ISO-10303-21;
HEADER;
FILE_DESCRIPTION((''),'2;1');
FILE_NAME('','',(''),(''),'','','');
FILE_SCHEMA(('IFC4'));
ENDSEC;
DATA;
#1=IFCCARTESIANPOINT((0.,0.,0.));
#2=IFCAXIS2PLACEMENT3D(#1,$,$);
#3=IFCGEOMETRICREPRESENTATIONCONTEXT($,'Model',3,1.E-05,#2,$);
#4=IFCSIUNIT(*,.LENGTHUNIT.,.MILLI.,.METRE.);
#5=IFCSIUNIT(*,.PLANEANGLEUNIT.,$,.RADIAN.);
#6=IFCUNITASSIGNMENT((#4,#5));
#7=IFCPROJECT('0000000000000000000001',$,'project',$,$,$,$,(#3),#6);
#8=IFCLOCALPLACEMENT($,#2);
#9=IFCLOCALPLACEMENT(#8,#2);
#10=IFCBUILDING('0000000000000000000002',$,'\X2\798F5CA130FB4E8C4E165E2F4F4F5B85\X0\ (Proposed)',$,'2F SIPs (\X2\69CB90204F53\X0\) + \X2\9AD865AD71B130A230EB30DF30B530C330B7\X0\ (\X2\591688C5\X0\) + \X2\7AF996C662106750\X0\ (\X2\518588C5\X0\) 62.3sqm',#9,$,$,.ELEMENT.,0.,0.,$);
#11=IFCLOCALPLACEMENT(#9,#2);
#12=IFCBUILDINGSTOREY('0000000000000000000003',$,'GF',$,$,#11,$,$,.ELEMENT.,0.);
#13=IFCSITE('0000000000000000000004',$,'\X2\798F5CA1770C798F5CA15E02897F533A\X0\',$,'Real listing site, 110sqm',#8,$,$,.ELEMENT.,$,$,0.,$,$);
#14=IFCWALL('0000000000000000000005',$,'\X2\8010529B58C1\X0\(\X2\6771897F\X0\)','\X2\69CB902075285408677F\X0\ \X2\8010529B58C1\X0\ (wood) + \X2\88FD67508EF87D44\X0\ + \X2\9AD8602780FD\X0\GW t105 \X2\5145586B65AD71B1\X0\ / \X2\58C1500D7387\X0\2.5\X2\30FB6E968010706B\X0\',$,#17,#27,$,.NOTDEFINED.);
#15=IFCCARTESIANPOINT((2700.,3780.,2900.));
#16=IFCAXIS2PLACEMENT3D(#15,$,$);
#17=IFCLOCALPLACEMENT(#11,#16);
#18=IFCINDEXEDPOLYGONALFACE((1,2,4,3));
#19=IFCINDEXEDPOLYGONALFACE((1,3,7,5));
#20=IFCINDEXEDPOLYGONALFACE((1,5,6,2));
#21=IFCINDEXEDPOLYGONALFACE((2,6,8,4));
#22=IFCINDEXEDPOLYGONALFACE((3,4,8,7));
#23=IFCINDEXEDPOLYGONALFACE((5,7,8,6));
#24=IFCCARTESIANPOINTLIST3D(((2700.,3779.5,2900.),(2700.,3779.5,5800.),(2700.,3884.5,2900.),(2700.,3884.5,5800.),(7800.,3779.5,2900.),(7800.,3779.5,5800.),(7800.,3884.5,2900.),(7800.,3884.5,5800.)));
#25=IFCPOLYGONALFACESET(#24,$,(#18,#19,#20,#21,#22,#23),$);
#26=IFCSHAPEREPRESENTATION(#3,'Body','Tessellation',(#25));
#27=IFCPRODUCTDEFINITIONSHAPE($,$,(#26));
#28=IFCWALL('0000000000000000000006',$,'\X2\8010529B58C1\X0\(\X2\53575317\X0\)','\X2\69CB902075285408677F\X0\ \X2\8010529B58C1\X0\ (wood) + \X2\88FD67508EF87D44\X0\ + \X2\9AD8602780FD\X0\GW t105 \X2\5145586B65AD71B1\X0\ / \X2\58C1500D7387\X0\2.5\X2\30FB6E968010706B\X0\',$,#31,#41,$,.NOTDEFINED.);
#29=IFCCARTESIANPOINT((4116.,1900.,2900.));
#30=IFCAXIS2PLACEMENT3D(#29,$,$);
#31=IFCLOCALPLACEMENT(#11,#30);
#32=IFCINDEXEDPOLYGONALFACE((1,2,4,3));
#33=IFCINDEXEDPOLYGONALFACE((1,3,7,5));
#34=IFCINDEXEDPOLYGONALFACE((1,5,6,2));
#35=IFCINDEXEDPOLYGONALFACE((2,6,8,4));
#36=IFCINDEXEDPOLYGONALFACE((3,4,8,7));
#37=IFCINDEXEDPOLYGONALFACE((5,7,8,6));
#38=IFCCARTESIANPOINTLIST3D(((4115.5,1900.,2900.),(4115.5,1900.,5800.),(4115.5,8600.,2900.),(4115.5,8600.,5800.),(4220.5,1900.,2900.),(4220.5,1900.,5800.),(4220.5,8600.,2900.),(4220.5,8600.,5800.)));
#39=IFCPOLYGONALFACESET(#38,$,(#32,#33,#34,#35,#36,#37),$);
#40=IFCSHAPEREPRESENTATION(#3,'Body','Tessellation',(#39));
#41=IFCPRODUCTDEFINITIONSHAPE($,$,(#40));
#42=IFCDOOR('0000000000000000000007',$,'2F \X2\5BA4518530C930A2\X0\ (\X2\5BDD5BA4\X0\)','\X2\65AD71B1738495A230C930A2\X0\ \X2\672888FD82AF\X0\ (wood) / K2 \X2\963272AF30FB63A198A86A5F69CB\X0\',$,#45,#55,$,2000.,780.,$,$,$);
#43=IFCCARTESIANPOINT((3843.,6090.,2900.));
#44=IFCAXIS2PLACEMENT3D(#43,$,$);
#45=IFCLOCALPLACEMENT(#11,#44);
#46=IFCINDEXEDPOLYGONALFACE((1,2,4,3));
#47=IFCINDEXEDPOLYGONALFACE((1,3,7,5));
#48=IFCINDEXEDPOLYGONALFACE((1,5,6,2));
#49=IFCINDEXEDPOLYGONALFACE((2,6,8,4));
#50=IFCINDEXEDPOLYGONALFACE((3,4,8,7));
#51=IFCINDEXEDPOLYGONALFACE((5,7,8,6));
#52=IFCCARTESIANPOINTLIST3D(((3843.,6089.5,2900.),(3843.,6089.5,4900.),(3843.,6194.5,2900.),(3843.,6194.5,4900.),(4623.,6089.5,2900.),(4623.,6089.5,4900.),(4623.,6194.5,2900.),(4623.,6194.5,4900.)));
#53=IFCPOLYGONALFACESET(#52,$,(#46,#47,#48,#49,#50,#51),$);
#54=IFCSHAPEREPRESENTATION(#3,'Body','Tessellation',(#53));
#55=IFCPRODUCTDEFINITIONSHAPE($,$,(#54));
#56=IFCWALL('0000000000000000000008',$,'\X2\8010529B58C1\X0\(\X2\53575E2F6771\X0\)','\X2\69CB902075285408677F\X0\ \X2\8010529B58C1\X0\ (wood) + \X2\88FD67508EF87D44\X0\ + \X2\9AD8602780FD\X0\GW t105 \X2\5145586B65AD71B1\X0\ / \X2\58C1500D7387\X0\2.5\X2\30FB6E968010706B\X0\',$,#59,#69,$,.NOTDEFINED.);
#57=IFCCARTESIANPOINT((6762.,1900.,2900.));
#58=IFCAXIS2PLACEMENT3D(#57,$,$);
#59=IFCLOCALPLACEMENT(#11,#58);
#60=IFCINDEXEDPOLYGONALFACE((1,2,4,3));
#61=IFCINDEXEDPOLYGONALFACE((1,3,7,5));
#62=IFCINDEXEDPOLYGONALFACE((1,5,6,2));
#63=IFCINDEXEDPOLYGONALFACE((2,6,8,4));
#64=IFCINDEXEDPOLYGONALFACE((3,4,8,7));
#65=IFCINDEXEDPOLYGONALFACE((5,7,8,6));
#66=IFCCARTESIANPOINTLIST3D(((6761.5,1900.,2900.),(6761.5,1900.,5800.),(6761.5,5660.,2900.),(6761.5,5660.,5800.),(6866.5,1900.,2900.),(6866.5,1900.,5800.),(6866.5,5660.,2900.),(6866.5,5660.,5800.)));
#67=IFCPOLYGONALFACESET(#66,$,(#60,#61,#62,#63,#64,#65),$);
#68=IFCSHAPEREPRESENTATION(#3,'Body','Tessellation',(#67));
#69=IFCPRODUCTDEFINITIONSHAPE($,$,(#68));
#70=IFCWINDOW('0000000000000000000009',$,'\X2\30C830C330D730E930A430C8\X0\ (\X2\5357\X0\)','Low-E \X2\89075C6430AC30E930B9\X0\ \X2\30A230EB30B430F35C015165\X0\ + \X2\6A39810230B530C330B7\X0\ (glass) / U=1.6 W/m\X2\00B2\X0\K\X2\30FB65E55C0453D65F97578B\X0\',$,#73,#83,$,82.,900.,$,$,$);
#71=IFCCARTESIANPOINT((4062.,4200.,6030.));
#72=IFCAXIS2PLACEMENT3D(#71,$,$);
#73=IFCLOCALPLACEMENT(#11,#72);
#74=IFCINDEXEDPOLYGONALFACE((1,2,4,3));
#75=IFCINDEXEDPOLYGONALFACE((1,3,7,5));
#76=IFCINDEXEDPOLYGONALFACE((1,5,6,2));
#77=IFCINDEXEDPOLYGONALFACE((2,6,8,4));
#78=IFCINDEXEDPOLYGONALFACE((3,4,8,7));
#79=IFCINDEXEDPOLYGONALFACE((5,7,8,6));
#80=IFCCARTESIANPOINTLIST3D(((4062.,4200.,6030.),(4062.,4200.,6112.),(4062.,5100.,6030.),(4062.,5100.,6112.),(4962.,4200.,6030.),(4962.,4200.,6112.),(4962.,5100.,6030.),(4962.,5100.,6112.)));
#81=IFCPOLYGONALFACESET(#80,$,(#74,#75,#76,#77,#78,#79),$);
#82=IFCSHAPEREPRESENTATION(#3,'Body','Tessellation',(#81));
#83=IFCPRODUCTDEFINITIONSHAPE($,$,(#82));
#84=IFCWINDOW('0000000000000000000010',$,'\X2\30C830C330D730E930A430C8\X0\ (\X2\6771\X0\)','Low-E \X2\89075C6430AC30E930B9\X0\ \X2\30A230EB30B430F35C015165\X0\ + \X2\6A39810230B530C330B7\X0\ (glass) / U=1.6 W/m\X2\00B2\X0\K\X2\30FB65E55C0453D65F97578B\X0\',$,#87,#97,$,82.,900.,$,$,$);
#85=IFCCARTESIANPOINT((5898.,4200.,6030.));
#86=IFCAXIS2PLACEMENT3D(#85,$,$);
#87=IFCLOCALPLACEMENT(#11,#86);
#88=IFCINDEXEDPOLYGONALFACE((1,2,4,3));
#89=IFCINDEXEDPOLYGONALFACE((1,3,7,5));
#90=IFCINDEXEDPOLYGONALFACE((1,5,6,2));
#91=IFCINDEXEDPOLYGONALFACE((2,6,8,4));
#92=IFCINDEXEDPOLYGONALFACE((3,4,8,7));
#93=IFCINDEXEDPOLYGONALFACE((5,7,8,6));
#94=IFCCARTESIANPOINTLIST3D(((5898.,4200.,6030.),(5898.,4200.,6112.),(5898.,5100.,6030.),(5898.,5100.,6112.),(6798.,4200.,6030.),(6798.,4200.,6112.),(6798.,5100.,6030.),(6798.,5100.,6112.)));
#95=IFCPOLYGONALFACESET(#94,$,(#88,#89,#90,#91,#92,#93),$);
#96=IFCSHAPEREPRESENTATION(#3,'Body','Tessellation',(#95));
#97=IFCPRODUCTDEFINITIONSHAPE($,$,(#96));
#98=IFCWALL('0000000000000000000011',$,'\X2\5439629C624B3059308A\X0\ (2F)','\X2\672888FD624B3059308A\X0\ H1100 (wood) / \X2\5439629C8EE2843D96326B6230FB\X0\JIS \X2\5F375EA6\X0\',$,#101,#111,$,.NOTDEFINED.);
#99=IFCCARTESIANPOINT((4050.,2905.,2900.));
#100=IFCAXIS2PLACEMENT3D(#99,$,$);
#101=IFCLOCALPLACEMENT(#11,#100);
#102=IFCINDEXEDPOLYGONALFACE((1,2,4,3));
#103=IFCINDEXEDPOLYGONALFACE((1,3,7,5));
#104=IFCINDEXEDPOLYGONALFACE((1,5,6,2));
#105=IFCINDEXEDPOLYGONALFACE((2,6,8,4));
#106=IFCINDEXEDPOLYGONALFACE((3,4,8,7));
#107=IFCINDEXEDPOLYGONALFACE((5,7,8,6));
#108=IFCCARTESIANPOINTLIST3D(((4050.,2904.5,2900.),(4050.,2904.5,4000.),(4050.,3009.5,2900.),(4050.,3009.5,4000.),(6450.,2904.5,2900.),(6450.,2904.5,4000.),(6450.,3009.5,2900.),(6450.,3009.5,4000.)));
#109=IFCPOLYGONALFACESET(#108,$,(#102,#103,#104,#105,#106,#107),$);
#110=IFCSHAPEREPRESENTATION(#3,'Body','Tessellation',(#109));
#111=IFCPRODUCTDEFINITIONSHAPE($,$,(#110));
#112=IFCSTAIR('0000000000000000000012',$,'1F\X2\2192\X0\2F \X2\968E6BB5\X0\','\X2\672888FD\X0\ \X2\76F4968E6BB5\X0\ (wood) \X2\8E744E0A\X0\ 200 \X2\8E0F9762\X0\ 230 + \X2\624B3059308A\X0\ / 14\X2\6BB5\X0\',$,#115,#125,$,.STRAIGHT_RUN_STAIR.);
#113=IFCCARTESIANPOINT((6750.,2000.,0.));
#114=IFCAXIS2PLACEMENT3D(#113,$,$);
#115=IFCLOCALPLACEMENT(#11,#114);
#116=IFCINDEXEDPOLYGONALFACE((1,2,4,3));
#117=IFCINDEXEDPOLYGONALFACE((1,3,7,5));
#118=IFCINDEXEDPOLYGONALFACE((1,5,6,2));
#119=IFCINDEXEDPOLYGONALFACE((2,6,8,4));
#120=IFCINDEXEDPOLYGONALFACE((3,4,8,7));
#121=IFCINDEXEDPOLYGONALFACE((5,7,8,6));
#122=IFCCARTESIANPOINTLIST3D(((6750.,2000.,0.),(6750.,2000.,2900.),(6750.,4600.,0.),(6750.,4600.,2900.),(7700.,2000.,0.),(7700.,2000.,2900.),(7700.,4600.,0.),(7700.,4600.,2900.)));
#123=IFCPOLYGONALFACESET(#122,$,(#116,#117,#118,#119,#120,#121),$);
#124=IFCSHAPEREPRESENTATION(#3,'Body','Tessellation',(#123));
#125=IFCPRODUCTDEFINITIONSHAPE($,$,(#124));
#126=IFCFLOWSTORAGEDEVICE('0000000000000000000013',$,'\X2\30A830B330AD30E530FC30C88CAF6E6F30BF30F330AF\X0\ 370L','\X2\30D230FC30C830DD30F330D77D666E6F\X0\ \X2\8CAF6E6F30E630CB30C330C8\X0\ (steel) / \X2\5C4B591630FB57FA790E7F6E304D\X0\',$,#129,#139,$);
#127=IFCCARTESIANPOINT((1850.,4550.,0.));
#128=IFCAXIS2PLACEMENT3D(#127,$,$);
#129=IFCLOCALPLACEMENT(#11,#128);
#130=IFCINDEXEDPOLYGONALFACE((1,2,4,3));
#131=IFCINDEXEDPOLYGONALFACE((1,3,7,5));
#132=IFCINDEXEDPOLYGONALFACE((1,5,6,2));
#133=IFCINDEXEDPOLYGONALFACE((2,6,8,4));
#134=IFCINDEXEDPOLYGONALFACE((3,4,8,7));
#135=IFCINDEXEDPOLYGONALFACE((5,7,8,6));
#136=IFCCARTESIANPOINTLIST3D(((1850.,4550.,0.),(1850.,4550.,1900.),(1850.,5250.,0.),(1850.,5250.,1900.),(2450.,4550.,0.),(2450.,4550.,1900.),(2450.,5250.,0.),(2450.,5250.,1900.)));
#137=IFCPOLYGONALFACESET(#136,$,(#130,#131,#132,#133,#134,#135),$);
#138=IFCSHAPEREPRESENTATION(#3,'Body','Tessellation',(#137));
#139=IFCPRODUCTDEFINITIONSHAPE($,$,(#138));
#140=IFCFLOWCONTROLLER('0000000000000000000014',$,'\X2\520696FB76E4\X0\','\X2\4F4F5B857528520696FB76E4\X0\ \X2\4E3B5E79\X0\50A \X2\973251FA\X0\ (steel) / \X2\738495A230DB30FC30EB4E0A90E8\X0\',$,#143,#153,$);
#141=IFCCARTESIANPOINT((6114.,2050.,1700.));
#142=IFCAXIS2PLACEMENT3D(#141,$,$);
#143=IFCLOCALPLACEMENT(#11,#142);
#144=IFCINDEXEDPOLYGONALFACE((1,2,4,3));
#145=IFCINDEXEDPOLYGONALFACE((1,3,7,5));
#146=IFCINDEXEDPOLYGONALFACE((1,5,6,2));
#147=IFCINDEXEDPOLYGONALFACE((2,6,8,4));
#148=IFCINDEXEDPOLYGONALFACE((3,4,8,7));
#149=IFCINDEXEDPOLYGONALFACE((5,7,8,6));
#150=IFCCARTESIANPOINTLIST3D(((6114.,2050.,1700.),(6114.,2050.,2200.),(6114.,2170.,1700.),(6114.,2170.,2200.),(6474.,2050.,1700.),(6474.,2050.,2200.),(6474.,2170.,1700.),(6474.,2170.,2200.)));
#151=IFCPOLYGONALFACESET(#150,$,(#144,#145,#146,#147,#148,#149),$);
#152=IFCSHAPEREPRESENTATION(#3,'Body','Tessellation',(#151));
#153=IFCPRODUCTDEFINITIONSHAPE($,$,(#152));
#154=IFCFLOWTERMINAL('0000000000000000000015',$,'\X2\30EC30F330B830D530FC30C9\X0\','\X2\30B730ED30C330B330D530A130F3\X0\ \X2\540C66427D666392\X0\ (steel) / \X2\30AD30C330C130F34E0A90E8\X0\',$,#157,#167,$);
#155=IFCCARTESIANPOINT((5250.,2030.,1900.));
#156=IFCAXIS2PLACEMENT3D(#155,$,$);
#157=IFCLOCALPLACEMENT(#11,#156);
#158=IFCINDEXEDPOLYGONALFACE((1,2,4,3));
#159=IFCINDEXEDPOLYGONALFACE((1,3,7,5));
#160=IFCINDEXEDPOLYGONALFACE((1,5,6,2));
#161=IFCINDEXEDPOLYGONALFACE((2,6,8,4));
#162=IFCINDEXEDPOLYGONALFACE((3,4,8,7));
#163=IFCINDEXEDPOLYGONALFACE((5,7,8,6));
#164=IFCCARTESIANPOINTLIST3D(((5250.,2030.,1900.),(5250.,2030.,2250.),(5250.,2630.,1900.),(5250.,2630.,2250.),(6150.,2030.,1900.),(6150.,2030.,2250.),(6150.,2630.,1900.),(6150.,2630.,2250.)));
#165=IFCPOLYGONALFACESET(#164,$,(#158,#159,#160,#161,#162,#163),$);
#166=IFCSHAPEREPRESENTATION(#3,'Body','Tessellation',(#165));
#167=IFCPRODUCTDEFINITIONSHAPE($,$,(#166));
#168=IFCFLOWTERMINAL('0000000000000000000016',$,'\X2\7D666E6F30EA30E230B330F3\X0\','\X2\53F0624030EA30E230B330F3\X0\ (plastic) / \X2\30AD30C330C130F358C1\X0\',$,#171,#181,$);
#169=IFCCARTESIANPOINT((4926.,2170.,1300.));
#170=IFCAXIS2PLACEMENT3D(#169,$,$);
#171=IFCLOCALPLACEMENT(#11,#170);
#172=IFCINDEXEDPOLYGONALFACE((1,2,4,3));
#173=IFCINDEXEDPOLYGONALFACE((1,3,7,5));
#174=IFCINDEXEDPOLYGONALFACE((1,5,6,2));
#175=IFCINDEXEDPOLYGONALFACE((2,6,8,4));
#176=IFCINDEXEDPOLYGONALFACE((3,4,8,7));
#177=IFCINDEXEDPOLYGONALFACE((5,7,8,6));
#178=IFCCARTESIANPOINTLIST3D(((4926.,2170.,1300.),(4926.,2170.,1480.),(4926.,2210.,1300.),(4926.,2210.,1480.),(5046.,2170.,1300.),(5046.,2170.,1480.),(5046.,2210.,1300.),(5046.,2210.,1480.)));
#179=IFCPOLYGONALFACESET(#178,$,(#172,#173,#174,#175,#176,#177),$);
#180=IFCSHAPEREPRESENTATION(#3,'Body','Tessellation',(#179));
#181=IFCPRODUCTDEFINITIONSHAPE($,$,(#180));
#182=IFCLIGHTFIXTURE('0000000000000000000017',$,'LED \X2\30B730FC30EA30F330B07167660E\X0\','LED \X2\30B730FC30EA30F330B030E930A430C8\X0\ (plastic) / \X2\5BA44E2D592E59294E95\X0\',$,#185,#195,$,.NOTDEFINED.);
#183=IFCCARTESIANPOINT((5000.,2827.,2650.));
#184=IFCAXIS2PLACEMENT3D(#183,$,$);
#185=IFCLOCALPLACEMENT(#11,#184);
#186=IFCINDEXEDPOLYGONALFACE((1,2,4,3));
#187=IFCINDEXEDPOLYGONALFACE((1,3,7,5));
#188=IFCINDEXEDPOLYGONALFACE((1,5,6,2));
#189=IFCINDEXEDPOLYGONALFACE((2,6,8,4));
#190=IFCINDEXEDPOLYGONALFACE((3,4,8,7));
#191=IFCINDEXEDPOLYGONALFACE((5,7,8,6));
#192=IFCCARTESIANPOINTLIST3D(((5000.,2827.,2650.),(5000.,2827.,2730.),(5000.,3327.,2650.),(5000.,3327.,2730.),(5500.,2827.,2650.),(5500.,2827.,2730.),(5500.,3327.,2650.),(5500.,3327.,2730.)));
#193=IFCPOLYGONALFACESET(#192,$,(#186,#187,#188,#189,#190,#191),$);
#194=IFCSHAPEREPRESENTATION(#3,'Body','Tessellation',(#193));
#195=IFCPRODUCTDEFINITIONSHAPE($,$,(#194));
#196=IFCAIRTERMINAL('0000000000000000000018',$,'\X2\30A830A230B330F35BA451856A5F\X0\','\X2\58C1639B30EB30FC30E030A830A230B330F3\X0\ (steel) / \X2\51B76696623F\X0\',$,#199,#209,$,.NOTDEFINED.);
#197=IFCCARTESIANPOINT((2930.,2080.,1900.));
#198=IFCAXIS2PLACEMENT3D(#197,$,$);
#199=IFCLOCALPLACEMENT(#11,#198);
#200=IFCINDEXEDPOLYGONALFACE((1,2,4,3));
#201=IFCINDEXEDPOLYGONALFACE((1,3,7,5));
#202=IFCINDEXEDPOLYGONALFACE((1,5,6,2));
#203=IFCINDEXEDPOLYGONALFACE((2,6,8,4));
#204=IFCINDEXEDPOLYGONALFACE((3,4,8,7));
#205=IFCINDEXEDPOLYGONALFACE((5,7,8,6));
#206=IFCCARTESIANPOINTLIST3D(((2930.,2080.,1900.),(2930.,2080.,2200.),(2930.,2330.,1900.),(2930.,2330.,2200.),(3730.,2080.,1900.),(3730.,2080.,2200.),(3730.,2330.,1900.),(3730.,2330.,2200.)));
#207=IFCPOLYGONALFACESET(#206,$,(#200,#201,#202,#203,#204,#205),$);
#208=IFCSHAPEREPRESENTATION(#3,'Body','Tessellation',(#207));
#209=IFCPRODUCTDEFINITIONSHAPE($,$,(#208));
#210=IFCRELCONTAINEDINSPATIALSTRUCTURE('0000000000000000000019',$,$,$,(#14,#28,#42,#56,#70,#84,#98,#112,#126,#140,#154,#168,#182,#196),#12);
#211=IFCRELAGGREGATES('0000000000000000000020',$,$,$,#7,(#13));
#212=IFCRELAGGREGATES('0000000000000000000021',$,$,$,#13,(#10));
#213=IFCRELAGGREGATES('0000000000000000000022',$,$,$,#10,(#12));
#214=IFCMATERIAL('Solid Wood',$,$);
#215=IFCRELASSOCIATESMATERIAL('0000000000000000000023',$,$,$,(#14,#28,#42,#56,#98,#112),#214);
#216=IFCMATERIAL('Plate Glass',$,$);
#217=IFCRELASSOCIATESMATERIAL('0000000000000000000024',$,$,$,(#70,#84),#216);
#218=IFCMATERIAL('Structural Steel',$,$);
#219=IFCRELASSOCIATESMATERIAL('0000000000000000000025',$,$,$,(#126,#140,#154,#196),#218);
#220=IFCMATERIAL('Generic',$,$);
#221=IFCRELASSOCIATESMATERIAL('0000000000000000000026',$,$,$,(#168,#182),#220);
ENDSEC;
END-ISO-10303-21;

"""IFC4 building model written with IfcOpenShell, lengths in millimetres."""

from ifc_helpers import new_model, si_unit, frame, frame_2d, origin, place, context, project, spatial, rectangle, extrude, material, element, fill, save


model = new_model("IFC4")

# Units and contexts
model_context = context("Model", 3, precision=1e-05, world=origin())
ifc_project = project(units=[si_unit("LENGTHUNIT", "METRE", prefix="MILLI"), si_unit("PLANEANGLEUNIT", "RADIAN")], contexts=[model_context])

# Site, building, storey
site_placement = place(None, origin())
site = spatial("IfcSite", under=ifc_project, at=site_placement, Name="福岡県福岡市西区", ObjectType="Real listing site, 110sqm", CompositionType="ELEMENT", RefElevation=0.0)
building_placement = place(site_placement, origin())
building = spatial("IfcBuilding", under=site, at=building_placement, Name="福岡・二世帯住宅 (Proposed)", ObjectType="2F SIPs (構造体) + 高断熱アルミサッシ (外装) + 竹集成材 (内装) 62.3sqm", CompositionType="ELEMENT", ElevationOfRefHeight=0.0, ElevationOfTerrain=0.0)
storey_placement = place(building_placement, origin())
storey = spatial("IfcBuildingStorey", under=building, at=storey_placement, Name="GF", CompositionType="ELEMENT", Elevation=0.0)

# Shared definitions
ifc_material_1 = material(Name="Solid Wood")

# Wall
wall_1_placement = place(storey_placement, frame((2700.0, 3780.0, 2900.0)))
element("IfcWall", 1, at=wall_1_placement, inside=storey, material=ifc_material_1, Name="耐力壁(東西)", Description="構造用合板 耐力壁 (wood) + 製材軸組 + 高性能GW t105 充填断熱 / 壁倍率2.5・準耐火", PredefinedType="NOTDEFINED", context=model_context, shape_type="SweptSolid", body=[
    extrude(rectangle(XDim=5100.0, YDim=105.0, at=frame_2d((2550.0, 52.0))), frame((2700.0, 3780.0, 2900.0)), (0.0, 0.0, 1.0), 2900.0),
])

# Wall, opening, door
wall_2_placement = place(storey_placement, frame((4116.0, 1900.0, 2900.0)))
wall_2 = element("IfcWall", 2, at=wall_2_placement, inside=storey, material=ifc_material_1, Name="耐力壁(南北)", Description="構造用合板 耐力壁 (wood) + 製材軸組 + 高性能GW t105 充填断熱 / 壁倍率2.5・準耐火", PredefinedType="NOTDEFINED", context=model_context, shape_type="SweptSolid", body=[
    extrude(rectangle(XDim=105.0, YDim=6700.0, at=frame_2d((52.0, 3350.0))), frame((4116.0, 1900.0, 2900.0)), (0.0, 0.0, 1.0), 2900.0),
])
opening_placement = place(storey_placement, frame((3843.0, 6090.0, 2900.0)))
opening = element("IfcOpeningElement", 3, at=opening_placement, cuts=wall_2, PredefinedType="NOTDEFINED", context=model_context, shape_type="SweptSolid", body=[
    extrude(rectangle(XDim=780.0, YDim=105.0, at=frame_2d((390.0, 52.0))), frame((3843.0, 6090.0, 2900.0)), (0.0, 0.0, 1.0), 2000.0),
])
door_placement = place(storey_placement, frame((3843.0, 6090.0, 2900.0)))
door = element("IfcDoor", 4, at=door_placement, inside=storey, material=ifc_material_1, Name="2F 室内ドア (寝室)", Description="断熱玄関ドア 木製芯 (wood) / K2 防犯・採風機構", OverallHeight=2000.0, OverallWidth=780.0, context=model_context, shape_type="SweptSolid", body=[
    extrude(rectangle(XDim=780.0, YDim=105.0, at=frame_2d((390.0, 52.0))), frame((3843.0, 6090.0, 2900.0)), (0.0, 0.0, 1.0), 2000.0),
])
fill(opening, door)

# Wall
wall_3_placement = place(storey_placement, frame((6762.0, 1900.0, 2900.0)))
element("IfcWall", 5, at=wall_3_placement, inside=storey, material=ifc_material_1, Name="耐力壁(南帯東)", Description="構造用合板 耐力壁 (wood) + 製材軸組 + 高性能GW t105 充填断熱 / 壁倍率2.5・準耐火", PredefinedType="NOTDEFINED", context=model_context, shape_type="SweptSolid", body=[
    extrude(rectangle(XDim=105.0, YDim=3760.0, at=frame_2d((52.0, 1880.0))), frame((6762.0, 1900.0, 2900.0)), (0.0, 0.0, 1.0), 2900.0),
])

# Windows
ifc_material_2 = material(Name="Plate Glass")
window_1_placement = place(storey_placement, frame((4062.0, 4200.0, 6030.0)))
element("IfcWindow", 6, at=window_1_placement, inside=storey, material=ifc_material_2, Name="トップライト (南)", Description="Low-E 複層ガラス アルゴン封入 + 樹脂サッシ (glass) / U=1.6 W/m²K・日射取得型", OverallHeight=82.0, OverallWidth=900.0, context=model_context, shape_type="SweptSolid", body=[
    extrude(rectangle(XDim=900.0, YDim=900.0, at=frame_2d((450.0, 450.0))), frame((4062.0, 4200.0, 6030.0)), (0.0, 0.0, 1.0), 82.0),
])
window_2_placement = place(storey_placement, frame((5898.0, 4200.0, 6030.0)))
element("IfcWindow", 7, at=window_2_placement, inside=storey, material=ifc_material_2, Name="トップライト (東)", Description="Low-E 複層ガラス アルゴン封入 + 樹脂サッシ (glass) / U=1.6 W/m²K・日射取得型", OverallHeight=82.0, OverallWidth=900.0, context=model_context, shape_type="SweptSolid", body=[
    extrude(rectangle(XDim=900.0, YDim=900.0, at=frame_2d((450.0, 450.0))), frame((5898.0, 4200.0, 6030.0)), (0.0, 0.0, 1.0), 82.0),
])

# Wall
wall_4_placement = place(storey_placement, frame((4050.0, 2905.0, 2900.0)))
element("IfcWall", 8, at=wall_4_placement, inside=storey, material=ifc_material_1, Name="吹抜手すり (2F)", Description="木製手すり H1100 (wood) / 吹抜転落防止・JIS 強度", PredefinedType="NOTDEFINED", context=model_context, shape_type="SweptSolid", body=[
    extrude(rectangle(XDim=2400.0, YDim=105.0, at=frame_2d((1200.0, 52.0))), frame((4050.0, 2905.0, 2900.0)), (0.0, 0.0, 1.0), 1100.0),
])

# Stair
stair_placement = place(storey_placement, frame((6750.0, 2000.0, 0.0)))
element("IfcStair", 9, at=stair_placement, inside=storey, material=ifc_material_1, Name="1F→2F 階段", Description="木製 直階段 (wood) 蹴上 200 踏面 230 + 手すり / 14段", PredefinedType="STRAIGHT_RUN_STAIR", context=model_context, shape_type="SweptSolid", body=[
    extrude(rectangle(XDim=950.0, YDim=2600.0, at=frame_2d((475.0, 1300.0))), frame((6750.0, 2000.0, 0.0)), (0.0, 0.0, 1.0), 2900.0),
])

# Flow storage device
ifc_material_3 = material(Name="Structural Steel")
flow_storage_device_placement = place(storey_placement, frame((1850.0, 4550.0, 0.0)))
element("IfcFlowStorageDevice", 10, at=flow_storage_device_placement, inside=storey, material=ifc_material_3, Name="エコキュート貯湯タンク 370L", Description="ヒートポンプ給湯 貯湯ユニット (steel) / 屋外・基礎置き", context=model_context, shape_type="SweptSolid", body=[
    extrude(rectangle(XDim=600.0, YDim=700.0, at=frame_2d((300.0, 350.0))), frame((1850.0, 4550.0, 0.0)), (0.0, 0.0, 1.0), 1900.0),
])

# Flow controller
flow_controller_placement = place(storey_placement, frame((6114.0, 2050.0, 1700.0)))
element("IfcFlowController", 11, at=flow_controller_placement, inside=storey, material=ifc_material_3, Name="分電盤", Description="住宅用分電盤 主幹50A 露出 (steel) / 玄関ホール上部", context=model_context, shape_type="SweptSolid", body=[
    extrude(rectangle(XDim=360.0, YDim=120.0, at=frame_2d((180.0, 60.0))), frame((6114.0, 2050.0, 1700.0)), (0.0, 0.0, 1.0), 500.0),
])

# Flow terminals
flow_terminal_1_placement = place(storey_placement, frame((5250.0, 2030.0, 1900.0)))
element("IfcFlowTerminal", 12, at=flow_terminal_1_placement, inside=storey, material=ifc_material_3, Name="レンジフード", Description="シロッコファン 同時給排 (steel) / キッチン上部", context=model_context, shape_type="SweptSolid", body=[
    extrude(rectangle(XDim=900.0, YDim=600.0, at=frame_2d((450.0, 300.0))), frame((5250.0, 2030.0, 1900.0)), (0.0, 0.0, 1.0), 350.0),
])
ifc_material_4 = material(Name="Generic")
flow_terminal_2_placement = place(storey_placement, frame((4926.0, 2170.0, 1300.0)))
element("IfcFlowTerminal", 13, at=flow_terminal_2_placement, inside=storey, material=ifc_material_4, Name="給湯リモコン", Description="台所リモコン (plastic) / キッチン壁", context=model_context, shape_type="SweptSolid", body=[
    extrude(rectangle(XDim=120.0, YDim=40.0, at=frame_2d((60.0, 20.0))), frame((4926.0, 2170.0, 1300.0)), (0.0, 0.0, 1.0), 180.0),
])

# Light fixture
light_fixture_1_placement = place(storey_placement, frame((5000.0, 2827.0, 2650.0)))
element("IfcLightFixture", 14, at=light_fixture_1_placement, inside=storey, material=ifc_material_4, Name="LED シーリング照明", Description="LED シーリングライト (plastic) / 室中央天井", PredefinedType="NOTDEFINED", context=model_context, shape_type="SweptSolid", body=[
    extrude(rectangle(XDim=500.0, YDim=500.0, at=frame_2d((250.0, 250.0))), frame((5000.0, 2827.0, 2650.0)), (0.0, 0.0, 1.0), 80.0),
])

# Air terminal
air_terminal_1_placement = place(storey_placement, frame((2930.0, 2080.0, 1900.0)))
element("IfcAirTerminal", 15, at=air_terminal_1_placement, inside=storey, material=ifc_material_3, Name="エアコン室内機", Description="壁掛ルームエアコン (steel) / 冷暖房", PredefinedType="NOTDEFINED", context=model_context, shape_type="SweptSolid", body=[
    extrude(rectangle(XDim=800.0, YDim=250.0, at=frame_2d((400.0, 125.0))), frame((2930.0, 2080.0, 1900.0)), (0.0, 0.0, 1.0), 300.0),
])

save(model, "model.ifc")
